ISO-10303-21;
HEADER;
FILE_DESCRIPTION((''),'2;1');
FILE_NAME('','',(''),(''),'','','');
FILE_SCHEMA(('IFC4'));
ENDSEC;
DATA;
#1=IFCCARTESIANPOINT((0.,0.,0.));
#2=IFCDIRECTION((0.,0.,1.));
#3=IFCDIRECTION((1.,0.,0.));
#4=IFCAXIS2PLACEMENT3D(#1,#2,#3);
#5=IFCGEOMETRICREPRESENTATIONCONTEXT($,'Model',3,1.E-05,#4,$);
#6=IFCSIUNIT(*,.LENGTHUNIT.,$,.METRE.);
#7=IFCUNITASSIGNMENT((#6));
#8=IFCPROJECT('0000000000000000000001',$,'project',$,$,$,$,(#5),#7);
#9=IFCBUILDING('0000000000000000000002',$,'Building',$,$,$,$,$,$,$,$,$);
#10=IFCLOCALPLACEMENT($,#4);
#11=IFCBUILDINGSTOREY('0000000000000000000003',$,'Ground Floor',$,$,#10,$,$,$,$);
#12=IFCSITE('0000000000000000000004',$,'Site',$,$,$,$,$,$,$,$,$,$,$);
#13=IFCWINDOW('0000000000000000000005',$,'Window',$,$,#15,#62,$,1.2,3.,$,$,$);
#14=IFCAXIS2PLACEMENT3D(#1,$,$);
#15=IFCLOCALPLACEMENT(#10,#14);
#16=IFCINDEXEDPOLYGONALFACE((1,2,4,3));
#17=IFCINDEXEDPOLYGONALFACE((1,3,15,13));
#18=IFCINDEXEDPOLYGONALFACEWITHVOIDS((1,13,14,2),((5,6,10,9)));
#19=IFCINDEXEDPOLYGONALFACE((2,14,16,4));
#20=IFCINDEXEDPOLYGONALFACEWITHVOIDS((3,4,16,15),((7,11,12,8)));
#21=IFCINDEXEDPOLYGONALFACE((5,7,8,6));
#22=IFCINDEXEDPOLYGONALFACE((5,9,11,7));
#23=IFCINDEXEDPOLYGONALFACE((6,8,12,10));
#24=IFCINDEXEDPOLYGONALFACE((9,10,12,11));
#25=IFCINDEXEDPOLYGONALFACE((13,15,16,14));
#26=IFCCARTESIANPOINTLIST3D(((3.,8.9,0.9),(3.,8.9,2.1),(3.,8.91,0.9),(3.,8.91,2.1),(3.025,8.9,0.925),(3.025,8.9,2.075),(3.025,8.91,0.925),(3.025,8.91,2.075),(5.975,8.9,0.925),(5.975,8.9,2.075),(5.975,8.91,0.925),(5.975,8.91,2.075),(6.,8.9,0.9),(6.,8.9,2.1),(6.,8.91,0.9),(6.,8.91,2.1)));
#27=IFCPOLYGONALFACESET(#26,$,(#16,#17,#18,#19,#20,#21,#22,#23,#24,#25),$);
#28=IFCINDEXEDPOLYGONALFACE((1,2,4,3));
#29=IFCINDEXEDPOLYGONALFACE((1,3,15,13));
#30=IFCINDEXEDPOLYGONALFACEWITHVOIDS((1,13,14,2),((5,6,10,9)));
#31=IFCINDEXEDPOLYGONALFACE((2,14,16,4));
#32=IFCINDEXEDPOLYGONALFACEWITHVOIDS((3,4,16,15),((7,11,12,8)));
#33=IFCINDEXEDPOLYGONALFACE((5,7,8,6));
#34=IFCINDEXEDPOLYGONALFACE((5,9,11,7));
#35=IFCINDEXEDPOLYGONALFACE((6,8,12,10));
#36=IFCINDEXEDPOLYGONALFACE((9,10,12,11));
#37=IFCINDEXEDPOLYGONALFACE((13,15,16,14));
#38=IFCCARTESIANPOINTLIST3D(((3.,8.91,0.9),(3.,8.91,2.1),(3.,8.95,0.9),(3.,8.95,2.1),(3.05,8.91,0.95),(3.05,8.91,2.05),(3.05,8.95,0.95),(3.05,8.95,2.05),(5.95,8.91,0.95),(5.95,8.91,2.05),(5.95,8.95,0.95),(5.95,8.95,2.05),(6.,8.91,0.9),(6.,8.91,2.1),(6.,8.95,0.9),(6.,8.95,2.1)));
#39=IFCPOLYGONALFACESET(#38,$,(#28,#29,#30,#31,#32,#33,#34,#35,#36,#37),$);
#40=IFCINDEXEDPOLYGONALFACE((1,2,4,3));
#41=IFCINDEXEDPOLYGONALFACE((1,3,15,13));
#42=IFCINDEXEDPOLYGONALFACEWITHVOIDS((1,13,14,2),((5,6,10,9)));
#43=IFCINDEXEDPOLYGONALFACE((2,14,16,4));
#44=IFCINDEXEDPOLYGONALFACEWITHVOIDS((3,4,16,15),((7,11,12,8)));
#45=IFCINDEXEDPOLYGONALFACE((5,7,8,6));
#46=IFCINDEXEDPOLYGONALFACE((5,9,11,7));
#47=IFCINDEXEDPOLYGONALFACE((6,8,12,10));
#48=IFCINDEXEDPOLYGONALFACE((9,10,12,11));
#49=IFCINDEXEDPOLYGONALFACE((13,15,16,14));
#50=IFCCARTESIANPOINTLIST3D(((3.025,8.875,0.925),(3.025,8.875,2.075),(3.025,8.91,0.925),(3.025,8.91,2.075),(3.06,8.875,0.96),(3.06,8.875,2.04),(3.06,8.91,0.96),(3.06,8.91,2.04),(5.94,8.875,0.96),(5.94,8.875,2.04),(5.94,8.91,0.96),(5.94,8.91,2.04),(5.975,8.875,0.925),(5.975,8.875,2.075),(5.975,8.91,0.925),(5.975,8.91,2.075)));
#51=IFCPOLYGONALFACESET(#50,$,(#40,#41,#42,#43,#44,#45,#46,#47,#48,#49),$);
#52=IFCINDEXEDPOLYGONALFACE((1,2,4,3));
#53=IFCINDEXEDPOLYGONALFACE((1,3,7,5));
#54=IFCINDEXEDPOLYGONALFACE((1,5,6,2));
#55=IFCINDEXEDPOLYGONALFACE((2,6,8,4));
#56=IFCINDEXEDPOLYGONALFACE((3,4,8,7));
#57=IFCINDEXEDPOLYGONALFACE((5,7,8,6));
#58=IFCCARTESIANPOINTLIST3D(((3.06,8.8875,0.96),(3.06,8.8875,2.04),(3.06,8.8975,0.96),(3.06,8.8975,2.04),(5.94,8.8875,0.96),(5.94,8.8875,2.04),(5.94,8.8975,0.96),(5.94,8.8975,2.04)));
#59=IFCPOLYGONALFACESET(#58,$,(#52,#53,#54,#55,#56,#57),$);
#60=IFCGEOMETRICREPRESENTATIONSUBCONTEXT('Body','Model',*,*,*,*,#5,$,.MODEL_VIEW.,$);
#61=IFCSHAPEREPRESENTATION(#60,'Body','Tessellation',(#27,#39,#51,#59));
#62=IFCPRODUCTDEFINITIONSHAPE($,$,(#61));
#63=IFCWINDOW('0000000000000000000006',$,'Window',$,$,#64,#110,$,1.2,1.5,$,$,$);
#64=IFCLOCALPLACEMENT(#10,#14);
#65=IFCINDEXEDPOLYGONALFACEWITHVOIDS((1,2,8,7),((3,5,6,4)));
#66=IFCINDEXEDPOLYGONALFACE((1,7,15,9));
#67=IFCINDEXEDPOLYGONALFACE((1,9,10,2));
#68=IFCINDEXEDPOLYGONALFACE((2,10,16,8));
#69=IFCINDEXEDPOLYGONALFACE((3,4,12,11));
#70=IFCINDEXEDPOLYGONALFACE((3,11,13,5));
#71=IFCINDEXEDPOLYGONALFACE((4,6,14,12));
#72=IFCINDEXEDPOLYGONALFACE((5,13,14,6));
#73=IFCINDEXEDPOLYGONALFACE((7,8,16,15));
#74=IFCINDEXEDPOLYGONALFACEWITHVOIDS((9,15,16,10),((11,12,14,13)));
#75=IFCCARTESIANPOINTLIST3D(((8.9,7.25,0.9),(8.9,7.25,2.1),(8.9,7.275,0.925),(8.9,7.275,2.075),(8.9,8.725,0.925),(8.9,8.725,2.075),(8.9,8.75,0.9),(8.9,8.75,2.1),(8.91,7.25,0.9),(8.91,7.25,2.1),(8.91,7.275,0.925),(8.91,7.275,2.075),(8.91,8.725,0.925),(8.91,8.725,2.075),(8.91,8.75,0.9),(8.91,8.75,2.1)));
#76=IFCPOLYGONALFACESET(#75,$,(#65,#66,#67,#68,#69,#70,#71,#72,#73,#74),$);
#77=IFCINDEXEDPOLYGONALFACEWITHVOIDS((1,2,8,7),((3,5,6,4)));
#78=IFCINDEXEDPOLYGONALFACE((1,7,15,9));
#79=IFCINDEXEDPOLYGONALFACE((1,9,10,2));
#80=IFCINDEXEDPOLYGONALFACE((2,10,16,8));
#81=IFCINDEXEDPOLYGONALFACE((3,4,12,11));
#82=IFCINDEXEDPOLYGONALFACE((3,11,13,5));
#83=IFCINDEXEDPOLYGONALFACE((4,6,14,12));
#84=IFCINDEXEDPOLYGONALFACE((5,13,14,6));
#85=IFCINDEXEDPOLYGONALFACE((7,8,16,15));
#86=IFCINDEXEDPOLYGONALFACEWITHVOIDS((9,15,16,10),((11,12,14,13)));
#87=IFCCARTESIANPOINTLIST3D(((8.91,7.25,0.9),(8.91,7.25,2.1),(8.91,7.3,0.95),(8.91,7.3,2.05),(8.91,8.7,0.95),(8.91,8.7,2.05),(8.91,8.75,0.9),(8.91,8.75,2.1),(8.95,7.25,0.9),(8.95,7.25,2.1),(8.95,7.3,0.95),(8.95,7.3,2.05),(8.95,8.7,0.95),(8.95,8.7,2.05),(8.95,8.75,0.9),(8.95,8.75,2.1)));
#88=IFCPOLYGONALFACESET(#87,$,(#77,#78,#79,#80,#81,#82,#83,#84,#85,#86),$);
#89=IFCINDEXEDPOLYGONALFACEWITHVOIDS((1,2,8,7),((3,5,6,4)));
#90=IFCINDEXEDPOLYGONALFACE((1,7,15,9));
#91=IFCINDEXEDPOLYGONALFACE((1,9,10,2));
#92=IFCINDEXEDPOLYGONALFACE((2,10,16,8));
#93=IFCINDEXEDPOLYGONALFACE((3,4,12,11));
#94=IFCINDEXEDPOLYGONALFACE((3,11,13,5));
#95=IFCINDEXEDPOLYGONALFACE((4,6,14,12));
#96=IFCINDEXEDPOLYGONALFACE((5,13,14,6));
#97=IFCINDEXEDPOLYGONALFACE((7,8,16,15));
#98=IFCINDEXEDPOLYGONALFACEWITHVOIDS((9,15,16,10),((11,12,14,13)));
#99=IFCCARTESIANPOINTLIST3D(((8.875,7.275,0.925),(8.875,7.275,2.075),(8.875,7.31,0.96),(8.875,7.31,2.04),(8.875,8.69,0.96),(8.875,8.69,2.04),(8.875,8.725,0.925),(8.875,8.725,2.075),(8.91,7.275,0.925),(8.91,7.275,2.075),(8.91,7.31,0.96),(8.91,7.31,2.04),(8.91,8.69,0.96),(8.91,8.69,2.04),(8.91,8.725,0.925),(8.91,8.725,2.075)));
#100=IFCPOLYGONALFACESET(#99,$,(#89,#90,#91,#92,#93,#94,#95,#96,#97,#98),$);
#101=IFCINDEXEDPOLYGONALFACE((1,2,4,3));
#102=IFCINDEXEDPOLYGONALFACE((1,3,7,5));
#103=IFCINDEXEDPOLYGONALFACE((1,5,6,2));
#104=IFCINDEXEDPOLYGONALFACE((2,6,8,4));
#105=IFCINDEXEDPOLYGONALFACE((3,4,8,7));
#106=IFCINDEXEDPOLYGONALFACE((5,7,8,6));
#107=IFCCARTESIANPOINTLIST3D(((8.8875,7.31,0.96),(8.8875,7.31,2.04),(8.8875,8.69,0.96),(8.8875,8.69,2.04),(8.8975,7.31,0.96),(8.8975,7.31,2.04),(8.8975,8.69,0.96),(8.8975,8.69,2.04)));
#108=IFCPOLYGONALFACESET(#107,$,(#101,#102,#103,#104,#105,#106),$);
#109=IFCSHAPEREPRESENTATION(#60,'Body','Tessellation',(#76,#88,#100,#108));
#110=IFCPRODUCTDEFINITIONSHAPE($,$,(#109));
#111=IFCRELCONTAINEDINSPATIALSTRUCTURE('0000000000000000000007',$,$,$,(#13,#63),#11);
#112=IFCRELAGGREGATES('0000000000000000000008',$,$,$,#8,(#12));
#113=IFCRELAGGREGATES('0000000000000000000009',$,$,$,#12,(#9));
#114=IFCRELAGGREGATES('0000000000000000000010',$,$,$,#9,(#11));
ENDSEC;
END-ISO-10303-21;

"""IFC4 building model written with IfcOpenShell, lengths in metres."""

from ifc_helpers import new_model, si_unit, frame, origin_with_axes, place, context, subcontext, project, spatial, line, indexed_curve, outline, extrude, element, save


model = new_model("IFC4")

# Units and contexts
model_context = context("Model", 3, precision=1e-05, world=origin_with_axes())
body_context = subcontext(model_context, "Body", "Model", "MODEL_VIEW")
ifc_project = project(units=[si_unit("LENGTHUNIT", "METRE")], contexts=[model_context])

# Site, building, storey
site = spatial("IfcSite", under=ifc_project, Name="Site")
building = spatial("IfcBuilding", under=site, Name="Building")
storey_placement = place(None, origin_with_axes())
storey = spatial("IfcBuildingStorey", under=building, at=storey_placement, Name="Ground Floor")

# Windows
window_1_placement = place(storey_placement, frame((6.0, 9.0, 0.9), z_axis=(0.0, 0.0, 1.0), x_axis=(-1.0, 0.0, 0.0)))
element("IfcWindow", 1, at=window_1_placement, inside=storey, Name="Window", OverallHeight=1.2, OverallWidth=3.0, context=body_context, shape_type="SweptSolid", body=[
    extrude(outline(indexed_curve([(0.0, 0.0), (3.0, 0.0), (3.0, 1.2), (0.0, 1.2)], segments=[line(1, 2, 3, 4, 1)]), holes=[indexed_curve([(0.025, 0.025), (2.975, 0.025), (2.975, 1.175), (0.025, 1.175)], segments=[line(1, 2, 3, 4, 1)])]), frame((0.0, 0.09, 0.0), z_axis=(0.0, -1.0, 0.0), x_axis=(1.0, 0.0, 0.0)), (0.0, 0.0, -1.0), 0.01),
    extrude(outline(indexed_curve([(0.0, 0.0), (3.0, 0.0), (3.0, 1.2), (0.0, 1.2)], segments=[line(1, 2, 3, 4, 1)]), holes=[indexed_curve([(0.05, 0.05), (2.95, 0.05), (2.95, 1.15), (0.05, 1.15)], segments=[line(1, 2, 3, 4, 1)])]), frame((0.0, 0.05, 0.0), z_axis=(0.0, -1.0, 0.0), x_axis=(1.0, 0.0, 0.0)), (0.0, 0.0, -1.0), 0.04),
    extrude(outline(indexed_curve([(0.0, 0.0), (2.95, 0.0), (2.95, 1.15), (0.0, 1.15)], segments=[line(1, 2, 3, 4, 1)]), holes=[indexed_curve([(0.035, 0.035), (2.915, 0.035), (2.915, 1.115), (0.035, 1.115)], segments=[line(1, 2, 3, 4, 1)])]), frame((0.025, 0.09, 0.025), z_axis=(0.0, -1.0, 0.0), x_axis=(1.0, 0.0, 0.0)), (0.0, 0.0, -1.0), 0.035),
    extrude(outline(indexed_curve([(0.035, 0.035), (2.915, 0.035), (2.915, 1.115), (0.035, 1.115)], segments=[line(1, 2, 3, 4, 1)])), frame((0.025, 0.1025, 0.025), z_axis=(0.0, -1.0, 0.0), x_axis=(1.0, 0.0, 0.0)), (0.0, 0.0, -1.0), 0.01),
])
window_2_placement = place(storey_placement, frame((9.0, 7.25, 0.9), z_axis=(0.0, 0.0, 1.0), x_axis=(0.0, 1.0, 0.0)))
element("IfcWindow", 2, at=window_2_placement, inside=storey, Name="Window", OverallHeight=1.2, OverallWidth=1.5, context=body_context, shape_type="SweptSolid", body=[
    extrude(outline(indexed_curve([(0.0, 0.0), (1.5, 0.0), (1.5, 1.2), (0.0, 1.2)], segments=[line(1, 2, 3, 4, 1)]), holes=[indexed_curve([(0.025, 0.025), (1.475, 0.025), (1.475, 1.175), (0.025, 1.175)], segments=[line(1, 2, 3, 4, 1)])]), frame((0.0, 0.09, 0.0), z_axis=(0.0, -1.0, 0.0), x_axis=(1.0, 0.0, 0.0)), (0.0, 0.0, -1.0), 0.01),
    extrude(outline(indexed_curve([(0.0, 0.0), (1.5, 0.0), (1.5, 1.2), (0.0, 1.2)], segments=[line(1, 2, 3, 4, 1)]), holes=[indexed_curve([(0.05, 0.05), (1.45, 0.05), (1.45, 1.15), (0.05, 1.15)], segments=[line(1, 2, 3, 4, 1)])]), frame((0.0, 0.05, 0.0), z_axis=(0.0, -1.0, 0.0), x_axis=(1.0, 0.0, 0.0)), (0.0, 0.0, -1.0), 0.04),
    extrude(outline(indexed_curve([(0.0, 0.0), (1.45, 0.0), (1.45, 1.15), (0.0, 1.15)], segments=[line(1, 2, 3, 4, 1)]), holes=[indexed_curve([(0.035, 0.035), (1.415, 0.035), (1.415, 1.115), (0.035, 1.115)], segments=[line(1, 2, 3, 4, 1)])]), frame((0.025, 0.09, 0.025), z_axis=(0.0, -1.0, 0.0), x_axis=(1.0, 0.0, 0.0)), (0.0, 0.0, -1.0), 0.035),
    extrude(outline(indexed_curve([(0.035, 0.035), (1.415, 0.035), (1.415, 1.115), (0.035, 1.115)], segments=[line(1, 2, 3, 4, 1)])), frame((0.025, 0.1025, 0.025), z_axis=(0.0, -1.0, 0.0), x_axis=(1.0, 0.0, 0.0)), (0.0, 0.0, -1.0), 0.01),
])

save(model, "model.ifc")
